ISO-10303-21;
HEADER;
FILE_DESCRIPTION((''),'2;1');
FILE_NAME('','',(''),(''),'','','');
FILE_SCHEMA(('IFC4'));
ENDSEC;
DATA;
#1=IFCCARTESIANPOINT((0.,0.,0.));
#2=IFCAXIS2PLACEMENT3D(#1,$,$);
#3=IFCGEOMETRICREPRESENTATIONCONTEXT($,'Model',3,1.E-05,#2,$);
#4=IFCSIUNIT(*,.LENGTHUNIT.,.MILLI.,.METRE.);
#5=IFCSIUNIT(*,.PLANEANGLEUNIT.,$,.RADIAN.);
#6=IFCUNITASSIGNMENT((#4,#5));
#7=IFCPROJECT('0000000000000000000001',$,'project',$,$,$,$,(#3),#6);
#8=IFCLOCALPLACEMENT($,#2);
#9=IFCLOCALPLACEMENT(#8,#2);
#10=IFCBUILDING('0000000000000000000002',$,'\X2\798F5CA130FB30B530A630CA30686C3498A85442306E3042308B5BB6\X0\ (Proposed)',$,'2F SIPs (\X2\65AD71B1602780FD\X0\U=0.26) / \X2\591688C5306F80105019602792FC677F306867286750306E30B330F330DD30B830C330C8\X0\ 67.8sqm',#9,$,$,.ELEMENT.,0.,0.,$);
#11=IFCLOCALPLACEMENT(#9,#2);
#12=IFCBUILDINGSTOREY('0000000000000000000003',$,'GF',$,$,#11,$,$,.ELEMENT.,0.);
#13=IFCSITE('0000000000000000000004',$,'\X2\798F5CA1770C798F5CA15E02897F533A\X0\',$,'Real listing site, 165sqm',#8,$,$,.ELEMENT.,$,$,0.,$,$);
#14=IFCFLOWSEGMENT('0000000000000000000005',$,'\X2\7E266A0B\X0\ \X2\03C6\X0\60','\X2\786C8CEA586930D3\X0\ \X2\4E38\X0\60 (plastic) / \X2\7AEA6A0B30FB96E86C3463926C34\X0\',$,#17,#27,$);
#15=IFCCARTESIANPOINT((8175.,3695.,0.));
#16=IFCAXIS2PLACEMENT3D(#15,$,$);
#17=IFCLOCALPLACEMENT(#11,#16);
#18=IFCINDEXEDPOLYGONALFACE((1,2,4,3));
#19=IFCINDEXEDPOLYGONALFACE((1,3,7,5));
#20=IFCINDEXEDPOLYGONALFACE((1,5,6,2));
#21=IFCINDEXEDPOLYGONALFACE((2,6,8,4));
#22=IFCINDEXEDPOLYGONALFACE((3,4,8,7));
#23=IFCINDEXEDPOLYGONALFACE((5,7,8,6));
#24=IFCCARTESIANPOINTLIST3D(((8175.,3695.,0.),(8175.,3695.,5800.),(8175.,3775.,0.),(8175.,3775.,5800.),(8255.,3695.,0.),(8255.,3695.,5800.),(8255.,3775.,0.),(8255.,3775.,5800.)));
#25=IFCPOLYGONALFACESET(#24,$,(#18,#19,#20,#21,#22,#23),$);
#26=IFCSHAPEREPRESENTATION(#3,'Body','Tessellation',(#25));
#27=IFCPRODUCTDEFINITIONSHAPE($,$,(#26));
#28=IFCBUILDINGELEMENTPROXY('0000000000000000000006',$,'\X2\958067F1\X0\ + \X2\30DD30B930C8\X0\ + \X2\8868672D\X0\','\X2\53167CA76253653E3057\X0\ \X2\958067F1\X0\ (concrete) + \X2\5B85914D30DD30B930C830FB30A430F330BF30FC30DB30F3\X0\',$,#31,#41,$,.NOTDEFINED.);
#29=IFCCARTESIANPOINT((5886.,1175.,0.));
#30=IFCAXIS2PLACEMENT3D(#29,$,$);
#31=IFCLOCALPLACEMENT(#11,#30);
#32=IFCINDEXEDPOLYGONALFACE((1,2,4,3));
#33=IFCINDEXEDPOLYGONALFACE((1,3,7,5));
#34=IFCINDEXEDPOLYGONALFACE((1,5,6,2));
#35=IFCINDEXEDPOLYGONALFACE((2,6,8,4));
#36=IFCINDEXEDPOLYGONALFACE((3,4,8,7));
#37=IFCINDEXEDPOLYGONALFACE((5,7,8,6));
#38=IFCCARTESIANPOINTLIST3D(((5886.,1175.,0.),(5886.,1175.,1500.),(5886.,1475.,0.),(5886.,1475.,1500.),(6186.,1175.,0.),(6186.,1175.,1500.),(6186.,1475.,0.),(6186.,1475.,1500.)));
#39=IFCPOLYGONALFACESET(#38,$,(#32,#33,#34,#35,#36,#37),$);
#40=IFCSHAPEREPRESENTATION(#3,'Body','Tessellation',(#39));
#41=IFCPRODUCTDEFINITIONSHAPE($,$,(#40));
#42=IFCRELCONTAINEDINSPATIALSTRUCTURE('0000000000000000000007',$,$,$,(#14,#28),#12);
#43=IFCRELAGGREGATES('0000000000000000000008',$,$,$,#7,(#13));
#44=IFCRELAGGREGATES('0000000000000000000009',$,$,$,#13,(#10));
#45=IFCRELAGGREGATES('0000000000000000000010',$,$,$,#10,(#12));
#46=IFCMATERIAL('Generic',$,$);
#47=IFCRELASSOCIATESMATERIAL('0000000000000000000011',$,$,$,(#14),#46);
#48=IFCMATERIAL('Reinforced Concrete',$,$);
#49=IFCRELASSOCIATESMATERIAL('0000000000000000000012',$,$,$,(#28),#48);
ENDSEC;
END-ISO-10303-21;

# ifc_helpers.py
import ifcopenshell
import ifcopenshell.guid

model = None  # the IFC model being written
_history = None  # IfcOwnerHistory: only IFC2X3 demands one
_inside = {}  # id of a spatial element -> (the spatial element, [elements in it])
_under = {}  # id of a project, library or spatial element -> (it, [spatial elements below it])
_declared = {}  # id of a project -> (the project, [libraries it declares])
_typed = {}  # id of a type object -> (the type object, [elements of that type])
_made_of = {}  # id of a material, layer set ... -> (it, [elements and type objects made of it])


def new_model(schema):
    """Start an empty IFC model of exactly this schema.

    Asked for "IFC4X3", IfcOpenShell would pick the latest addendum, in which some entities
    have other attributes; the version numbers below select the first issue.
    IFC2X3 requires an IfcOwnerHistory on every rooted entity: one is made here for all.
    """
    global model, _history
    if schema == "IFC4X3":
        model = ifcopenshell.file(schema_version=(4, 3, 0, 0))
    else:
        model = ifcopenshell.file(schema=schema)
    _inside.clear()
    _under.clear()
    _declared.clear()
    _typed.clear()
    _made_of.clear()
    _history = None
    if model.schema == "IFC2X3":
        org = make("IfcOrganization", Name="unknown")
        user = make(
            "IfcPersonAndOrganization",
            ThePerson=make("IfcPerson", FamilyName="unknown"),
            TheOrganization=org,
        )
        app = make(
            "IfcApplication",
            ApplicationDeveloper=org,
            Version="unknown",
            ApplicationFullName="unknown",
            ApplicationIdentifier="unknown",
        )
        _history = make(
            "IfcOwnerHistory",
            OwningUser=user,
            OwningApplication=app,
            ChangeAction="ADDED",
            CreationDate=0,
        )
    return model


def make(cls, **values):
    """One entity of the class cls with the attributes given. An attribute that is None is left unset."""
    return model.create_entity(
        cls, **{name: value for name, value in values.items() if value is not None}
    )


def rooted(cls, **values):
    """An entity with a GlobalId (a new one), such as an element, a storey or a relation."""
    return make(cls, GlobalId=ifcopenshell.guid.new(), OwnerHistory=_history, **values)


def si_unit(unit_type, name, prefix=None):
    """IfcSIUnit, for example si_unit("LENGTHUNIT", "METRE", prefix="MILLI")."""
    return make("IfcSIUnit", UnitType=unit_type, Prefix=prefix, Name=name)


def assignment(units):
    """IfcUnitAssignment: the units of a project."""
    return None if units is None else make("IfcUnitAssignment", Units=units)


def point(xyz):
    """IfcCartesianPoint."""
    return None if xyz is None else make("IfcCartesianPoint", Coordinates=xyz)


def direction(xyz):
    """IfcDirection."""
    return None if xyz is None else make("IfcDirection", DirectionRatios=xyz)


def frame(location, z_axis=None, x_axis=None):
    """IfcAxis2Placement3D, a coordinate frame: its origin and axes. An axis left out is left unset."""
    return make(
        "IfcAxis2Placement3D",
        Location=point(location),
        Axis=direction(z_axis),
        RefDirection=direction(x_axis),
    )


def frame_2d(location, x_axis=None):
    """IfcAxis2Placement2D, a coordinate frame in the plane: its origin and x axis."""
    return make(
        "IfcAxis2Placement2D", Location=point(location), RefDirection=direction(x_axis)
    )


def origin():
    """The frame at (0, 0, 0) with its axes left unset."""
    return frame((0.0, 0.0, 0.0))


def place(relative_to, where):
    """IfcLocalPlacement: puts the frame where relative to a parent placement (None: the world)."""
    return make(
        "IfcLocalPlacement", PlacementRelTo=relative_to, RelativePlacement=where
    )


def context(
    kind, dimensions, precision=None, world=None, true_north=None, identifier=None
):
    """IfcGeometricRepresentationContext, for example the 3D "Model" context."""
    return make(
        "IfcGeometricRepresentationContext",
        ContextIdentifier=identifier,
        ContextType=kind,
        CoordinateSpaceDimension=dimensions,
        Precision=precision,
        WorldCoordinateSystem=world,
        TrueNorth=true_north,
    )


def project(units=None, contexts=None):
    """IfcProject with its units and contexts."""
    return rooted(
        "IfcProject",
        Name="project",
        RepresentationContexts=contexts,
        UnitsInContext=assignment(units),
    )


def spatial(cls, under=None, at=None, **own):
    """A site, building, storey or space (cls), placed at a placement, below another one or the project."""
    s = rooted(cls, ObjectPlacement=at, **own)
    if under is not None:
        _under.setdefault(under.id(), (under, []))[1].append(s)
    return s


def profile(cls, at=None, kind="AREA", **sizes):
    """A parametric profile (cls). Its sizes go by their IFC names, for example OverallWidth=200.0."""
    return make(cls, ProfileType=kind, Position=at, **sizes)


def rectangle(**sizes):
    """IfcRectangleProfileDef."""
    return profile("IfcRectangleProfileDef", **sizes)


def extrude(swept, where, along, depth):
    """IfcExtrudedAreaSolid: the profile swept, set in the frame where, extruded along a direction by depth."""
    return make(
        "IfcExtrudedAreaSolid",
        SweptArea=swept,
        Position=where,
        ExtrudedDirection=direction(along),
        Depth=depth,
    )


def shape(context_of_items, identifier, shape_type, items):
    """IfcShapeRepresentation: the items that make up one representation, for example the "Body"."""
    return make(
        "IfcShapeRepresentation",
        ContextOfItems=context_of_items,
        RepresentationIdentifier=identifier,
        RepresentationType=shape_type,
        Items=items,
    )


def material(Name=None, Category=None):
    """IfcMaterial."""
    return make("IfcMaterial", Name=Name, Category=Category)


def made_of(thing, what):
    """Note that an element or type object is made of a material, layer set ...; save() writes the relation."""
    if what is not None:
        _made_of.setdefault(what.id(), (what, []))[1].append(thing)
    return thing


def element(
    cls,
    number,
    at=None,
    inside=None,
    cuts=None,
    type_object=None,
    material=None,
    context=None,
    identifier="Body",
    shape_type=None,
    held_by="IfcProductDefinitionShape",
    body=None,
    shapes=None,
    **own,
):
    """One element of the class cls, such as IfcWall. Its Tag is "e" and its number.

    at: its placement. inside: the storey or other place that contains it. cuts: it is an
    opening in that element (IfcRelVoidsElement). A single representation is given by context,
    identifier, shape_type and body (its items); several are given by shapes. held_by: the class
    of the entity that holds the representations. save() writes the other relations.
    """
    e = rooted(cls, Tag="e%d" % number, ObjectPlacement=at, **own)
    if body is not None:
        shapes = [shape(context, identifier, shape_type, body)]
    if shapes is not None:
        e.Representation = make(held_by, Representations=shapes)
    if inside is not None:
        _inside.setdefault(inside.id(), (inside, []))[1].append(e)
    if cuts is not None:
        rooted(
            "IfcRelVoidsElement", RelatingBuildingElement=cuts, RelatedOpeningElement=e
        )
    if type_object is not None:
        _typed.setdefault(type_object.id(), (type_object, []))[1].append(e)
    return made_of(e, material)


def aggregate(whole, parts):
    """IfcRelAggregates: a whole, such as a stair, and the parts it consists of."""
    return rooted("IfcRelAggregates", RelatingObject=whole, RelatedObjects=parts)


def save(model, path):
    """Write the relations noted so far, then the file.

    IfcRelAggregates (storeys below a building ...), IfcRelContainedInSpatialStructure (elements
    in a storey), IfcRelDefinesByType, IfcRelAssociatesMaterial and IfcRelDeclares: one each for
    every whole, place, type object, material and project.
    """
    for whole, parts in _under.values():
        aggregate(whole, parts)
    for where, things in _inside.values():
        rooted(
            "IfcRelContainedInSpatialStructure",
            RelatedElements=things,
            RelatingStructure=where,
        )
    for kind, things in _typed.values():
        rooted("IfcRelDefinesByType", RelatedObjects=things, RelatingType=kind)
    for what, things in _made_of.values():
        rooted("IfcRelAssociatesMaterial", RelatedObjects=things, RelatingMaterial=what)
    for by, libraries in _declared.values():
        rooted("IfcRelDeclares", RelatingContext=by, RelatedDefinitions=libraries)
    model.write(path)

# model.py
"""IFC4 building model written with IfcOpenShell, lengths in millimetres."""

from ifc_helpers import new_model, si_unit, frame, frame_2d, origin, place, context, project, spatial, rectangle, extrude, material, element, save


model = new_model("IFC4")

# Units and contexts
model_context = context("Model", 3, precision=1e-05, world=origin())
ifc_project = project(units=[si_unit("LENGTHUNIT", "METRE", prefix="MILLI"), si_unit("PLANEANGLEUNIT", "RADIAN")], contexts=[model_context])

# Site, building, storey
site_placement = place(None, origin())
site = spatial("IfcSite", under=ifc_project, at=site_placement, Name="福岡県福岡市西区", ObjectType="Real listing site, 165sqm", CompositionType="ELEMENT", RefElevation=0.0)
building_placement = place(site_placement, origin())
building = spatial("IfcBuilding", under=site, at=building_placement, Name="福岡・サウナと水風呂のある家 (Proposed)", ObjectType="2F SIPs (断熱性能U=0.26) / 外装は耐候性鋼板と木材のコンポジット 67.8sqm", CompositionType="ELEMENT", ElevationOfRefHeight=0.0, ElevationOfTerrain=0.0)
storey_placement = place(building_placement, origin())
storey = spatial("IfcBuildingStorey", under=building, at=storey_placement, Name="GF", CompositionType="ELEMENT", Elevation=0.0)

# Shared definitions
ifc_material_1 = material(Name="Generic")
ifc_material_2 = material(Name="Reinforced Concrete")

# Flow segment
flow_segment_placement = place(storey_placement, frame((8175.0, 3695.0, 0.0)))
element("IfcFlowSegment", 1, at=flow_segment_placement, inside=storey, material=ifc_material_1, Name="縦樋 φ60", Description="硬質塩ビ 丸60 (plastic) / 竪樋・雨水排水", context=model_context, shape_type="SweptSolid", body=[
    extrude(rectangle(XDim=80.0, YDim=80.0, at=frame_2d((40.0, 40.0))), frame((8175.0, 3695.0, 0.0)), (0.0, 0.0, 1.0), 5800.0),
])

# Building element proxy
proxy_placement = place(storey_placement, frame((5886.0, 1175.0, 0.0)))
element("IfcBuildingElementProxy", 2, at=proxy_placement, inside=storey, material=ifc_material_2, Name="門柱 + ポスト + 表札", Description="化粧打放し 門柱 (concrete) + 宅配ポスト・インターホン", PredefinedType="NOTDEFINED", context=model_context, shape_type="SweptSolid", body=[
    extrude(rectangle(XDim=300.0, YDim=300.0, at=frame_2d((150.0, 150.0))), frame((5886.0, 1175.0, 0.0)), (0.0, 0.0, 1.0), 1500.0),
])

save(model, "model.ifc")
